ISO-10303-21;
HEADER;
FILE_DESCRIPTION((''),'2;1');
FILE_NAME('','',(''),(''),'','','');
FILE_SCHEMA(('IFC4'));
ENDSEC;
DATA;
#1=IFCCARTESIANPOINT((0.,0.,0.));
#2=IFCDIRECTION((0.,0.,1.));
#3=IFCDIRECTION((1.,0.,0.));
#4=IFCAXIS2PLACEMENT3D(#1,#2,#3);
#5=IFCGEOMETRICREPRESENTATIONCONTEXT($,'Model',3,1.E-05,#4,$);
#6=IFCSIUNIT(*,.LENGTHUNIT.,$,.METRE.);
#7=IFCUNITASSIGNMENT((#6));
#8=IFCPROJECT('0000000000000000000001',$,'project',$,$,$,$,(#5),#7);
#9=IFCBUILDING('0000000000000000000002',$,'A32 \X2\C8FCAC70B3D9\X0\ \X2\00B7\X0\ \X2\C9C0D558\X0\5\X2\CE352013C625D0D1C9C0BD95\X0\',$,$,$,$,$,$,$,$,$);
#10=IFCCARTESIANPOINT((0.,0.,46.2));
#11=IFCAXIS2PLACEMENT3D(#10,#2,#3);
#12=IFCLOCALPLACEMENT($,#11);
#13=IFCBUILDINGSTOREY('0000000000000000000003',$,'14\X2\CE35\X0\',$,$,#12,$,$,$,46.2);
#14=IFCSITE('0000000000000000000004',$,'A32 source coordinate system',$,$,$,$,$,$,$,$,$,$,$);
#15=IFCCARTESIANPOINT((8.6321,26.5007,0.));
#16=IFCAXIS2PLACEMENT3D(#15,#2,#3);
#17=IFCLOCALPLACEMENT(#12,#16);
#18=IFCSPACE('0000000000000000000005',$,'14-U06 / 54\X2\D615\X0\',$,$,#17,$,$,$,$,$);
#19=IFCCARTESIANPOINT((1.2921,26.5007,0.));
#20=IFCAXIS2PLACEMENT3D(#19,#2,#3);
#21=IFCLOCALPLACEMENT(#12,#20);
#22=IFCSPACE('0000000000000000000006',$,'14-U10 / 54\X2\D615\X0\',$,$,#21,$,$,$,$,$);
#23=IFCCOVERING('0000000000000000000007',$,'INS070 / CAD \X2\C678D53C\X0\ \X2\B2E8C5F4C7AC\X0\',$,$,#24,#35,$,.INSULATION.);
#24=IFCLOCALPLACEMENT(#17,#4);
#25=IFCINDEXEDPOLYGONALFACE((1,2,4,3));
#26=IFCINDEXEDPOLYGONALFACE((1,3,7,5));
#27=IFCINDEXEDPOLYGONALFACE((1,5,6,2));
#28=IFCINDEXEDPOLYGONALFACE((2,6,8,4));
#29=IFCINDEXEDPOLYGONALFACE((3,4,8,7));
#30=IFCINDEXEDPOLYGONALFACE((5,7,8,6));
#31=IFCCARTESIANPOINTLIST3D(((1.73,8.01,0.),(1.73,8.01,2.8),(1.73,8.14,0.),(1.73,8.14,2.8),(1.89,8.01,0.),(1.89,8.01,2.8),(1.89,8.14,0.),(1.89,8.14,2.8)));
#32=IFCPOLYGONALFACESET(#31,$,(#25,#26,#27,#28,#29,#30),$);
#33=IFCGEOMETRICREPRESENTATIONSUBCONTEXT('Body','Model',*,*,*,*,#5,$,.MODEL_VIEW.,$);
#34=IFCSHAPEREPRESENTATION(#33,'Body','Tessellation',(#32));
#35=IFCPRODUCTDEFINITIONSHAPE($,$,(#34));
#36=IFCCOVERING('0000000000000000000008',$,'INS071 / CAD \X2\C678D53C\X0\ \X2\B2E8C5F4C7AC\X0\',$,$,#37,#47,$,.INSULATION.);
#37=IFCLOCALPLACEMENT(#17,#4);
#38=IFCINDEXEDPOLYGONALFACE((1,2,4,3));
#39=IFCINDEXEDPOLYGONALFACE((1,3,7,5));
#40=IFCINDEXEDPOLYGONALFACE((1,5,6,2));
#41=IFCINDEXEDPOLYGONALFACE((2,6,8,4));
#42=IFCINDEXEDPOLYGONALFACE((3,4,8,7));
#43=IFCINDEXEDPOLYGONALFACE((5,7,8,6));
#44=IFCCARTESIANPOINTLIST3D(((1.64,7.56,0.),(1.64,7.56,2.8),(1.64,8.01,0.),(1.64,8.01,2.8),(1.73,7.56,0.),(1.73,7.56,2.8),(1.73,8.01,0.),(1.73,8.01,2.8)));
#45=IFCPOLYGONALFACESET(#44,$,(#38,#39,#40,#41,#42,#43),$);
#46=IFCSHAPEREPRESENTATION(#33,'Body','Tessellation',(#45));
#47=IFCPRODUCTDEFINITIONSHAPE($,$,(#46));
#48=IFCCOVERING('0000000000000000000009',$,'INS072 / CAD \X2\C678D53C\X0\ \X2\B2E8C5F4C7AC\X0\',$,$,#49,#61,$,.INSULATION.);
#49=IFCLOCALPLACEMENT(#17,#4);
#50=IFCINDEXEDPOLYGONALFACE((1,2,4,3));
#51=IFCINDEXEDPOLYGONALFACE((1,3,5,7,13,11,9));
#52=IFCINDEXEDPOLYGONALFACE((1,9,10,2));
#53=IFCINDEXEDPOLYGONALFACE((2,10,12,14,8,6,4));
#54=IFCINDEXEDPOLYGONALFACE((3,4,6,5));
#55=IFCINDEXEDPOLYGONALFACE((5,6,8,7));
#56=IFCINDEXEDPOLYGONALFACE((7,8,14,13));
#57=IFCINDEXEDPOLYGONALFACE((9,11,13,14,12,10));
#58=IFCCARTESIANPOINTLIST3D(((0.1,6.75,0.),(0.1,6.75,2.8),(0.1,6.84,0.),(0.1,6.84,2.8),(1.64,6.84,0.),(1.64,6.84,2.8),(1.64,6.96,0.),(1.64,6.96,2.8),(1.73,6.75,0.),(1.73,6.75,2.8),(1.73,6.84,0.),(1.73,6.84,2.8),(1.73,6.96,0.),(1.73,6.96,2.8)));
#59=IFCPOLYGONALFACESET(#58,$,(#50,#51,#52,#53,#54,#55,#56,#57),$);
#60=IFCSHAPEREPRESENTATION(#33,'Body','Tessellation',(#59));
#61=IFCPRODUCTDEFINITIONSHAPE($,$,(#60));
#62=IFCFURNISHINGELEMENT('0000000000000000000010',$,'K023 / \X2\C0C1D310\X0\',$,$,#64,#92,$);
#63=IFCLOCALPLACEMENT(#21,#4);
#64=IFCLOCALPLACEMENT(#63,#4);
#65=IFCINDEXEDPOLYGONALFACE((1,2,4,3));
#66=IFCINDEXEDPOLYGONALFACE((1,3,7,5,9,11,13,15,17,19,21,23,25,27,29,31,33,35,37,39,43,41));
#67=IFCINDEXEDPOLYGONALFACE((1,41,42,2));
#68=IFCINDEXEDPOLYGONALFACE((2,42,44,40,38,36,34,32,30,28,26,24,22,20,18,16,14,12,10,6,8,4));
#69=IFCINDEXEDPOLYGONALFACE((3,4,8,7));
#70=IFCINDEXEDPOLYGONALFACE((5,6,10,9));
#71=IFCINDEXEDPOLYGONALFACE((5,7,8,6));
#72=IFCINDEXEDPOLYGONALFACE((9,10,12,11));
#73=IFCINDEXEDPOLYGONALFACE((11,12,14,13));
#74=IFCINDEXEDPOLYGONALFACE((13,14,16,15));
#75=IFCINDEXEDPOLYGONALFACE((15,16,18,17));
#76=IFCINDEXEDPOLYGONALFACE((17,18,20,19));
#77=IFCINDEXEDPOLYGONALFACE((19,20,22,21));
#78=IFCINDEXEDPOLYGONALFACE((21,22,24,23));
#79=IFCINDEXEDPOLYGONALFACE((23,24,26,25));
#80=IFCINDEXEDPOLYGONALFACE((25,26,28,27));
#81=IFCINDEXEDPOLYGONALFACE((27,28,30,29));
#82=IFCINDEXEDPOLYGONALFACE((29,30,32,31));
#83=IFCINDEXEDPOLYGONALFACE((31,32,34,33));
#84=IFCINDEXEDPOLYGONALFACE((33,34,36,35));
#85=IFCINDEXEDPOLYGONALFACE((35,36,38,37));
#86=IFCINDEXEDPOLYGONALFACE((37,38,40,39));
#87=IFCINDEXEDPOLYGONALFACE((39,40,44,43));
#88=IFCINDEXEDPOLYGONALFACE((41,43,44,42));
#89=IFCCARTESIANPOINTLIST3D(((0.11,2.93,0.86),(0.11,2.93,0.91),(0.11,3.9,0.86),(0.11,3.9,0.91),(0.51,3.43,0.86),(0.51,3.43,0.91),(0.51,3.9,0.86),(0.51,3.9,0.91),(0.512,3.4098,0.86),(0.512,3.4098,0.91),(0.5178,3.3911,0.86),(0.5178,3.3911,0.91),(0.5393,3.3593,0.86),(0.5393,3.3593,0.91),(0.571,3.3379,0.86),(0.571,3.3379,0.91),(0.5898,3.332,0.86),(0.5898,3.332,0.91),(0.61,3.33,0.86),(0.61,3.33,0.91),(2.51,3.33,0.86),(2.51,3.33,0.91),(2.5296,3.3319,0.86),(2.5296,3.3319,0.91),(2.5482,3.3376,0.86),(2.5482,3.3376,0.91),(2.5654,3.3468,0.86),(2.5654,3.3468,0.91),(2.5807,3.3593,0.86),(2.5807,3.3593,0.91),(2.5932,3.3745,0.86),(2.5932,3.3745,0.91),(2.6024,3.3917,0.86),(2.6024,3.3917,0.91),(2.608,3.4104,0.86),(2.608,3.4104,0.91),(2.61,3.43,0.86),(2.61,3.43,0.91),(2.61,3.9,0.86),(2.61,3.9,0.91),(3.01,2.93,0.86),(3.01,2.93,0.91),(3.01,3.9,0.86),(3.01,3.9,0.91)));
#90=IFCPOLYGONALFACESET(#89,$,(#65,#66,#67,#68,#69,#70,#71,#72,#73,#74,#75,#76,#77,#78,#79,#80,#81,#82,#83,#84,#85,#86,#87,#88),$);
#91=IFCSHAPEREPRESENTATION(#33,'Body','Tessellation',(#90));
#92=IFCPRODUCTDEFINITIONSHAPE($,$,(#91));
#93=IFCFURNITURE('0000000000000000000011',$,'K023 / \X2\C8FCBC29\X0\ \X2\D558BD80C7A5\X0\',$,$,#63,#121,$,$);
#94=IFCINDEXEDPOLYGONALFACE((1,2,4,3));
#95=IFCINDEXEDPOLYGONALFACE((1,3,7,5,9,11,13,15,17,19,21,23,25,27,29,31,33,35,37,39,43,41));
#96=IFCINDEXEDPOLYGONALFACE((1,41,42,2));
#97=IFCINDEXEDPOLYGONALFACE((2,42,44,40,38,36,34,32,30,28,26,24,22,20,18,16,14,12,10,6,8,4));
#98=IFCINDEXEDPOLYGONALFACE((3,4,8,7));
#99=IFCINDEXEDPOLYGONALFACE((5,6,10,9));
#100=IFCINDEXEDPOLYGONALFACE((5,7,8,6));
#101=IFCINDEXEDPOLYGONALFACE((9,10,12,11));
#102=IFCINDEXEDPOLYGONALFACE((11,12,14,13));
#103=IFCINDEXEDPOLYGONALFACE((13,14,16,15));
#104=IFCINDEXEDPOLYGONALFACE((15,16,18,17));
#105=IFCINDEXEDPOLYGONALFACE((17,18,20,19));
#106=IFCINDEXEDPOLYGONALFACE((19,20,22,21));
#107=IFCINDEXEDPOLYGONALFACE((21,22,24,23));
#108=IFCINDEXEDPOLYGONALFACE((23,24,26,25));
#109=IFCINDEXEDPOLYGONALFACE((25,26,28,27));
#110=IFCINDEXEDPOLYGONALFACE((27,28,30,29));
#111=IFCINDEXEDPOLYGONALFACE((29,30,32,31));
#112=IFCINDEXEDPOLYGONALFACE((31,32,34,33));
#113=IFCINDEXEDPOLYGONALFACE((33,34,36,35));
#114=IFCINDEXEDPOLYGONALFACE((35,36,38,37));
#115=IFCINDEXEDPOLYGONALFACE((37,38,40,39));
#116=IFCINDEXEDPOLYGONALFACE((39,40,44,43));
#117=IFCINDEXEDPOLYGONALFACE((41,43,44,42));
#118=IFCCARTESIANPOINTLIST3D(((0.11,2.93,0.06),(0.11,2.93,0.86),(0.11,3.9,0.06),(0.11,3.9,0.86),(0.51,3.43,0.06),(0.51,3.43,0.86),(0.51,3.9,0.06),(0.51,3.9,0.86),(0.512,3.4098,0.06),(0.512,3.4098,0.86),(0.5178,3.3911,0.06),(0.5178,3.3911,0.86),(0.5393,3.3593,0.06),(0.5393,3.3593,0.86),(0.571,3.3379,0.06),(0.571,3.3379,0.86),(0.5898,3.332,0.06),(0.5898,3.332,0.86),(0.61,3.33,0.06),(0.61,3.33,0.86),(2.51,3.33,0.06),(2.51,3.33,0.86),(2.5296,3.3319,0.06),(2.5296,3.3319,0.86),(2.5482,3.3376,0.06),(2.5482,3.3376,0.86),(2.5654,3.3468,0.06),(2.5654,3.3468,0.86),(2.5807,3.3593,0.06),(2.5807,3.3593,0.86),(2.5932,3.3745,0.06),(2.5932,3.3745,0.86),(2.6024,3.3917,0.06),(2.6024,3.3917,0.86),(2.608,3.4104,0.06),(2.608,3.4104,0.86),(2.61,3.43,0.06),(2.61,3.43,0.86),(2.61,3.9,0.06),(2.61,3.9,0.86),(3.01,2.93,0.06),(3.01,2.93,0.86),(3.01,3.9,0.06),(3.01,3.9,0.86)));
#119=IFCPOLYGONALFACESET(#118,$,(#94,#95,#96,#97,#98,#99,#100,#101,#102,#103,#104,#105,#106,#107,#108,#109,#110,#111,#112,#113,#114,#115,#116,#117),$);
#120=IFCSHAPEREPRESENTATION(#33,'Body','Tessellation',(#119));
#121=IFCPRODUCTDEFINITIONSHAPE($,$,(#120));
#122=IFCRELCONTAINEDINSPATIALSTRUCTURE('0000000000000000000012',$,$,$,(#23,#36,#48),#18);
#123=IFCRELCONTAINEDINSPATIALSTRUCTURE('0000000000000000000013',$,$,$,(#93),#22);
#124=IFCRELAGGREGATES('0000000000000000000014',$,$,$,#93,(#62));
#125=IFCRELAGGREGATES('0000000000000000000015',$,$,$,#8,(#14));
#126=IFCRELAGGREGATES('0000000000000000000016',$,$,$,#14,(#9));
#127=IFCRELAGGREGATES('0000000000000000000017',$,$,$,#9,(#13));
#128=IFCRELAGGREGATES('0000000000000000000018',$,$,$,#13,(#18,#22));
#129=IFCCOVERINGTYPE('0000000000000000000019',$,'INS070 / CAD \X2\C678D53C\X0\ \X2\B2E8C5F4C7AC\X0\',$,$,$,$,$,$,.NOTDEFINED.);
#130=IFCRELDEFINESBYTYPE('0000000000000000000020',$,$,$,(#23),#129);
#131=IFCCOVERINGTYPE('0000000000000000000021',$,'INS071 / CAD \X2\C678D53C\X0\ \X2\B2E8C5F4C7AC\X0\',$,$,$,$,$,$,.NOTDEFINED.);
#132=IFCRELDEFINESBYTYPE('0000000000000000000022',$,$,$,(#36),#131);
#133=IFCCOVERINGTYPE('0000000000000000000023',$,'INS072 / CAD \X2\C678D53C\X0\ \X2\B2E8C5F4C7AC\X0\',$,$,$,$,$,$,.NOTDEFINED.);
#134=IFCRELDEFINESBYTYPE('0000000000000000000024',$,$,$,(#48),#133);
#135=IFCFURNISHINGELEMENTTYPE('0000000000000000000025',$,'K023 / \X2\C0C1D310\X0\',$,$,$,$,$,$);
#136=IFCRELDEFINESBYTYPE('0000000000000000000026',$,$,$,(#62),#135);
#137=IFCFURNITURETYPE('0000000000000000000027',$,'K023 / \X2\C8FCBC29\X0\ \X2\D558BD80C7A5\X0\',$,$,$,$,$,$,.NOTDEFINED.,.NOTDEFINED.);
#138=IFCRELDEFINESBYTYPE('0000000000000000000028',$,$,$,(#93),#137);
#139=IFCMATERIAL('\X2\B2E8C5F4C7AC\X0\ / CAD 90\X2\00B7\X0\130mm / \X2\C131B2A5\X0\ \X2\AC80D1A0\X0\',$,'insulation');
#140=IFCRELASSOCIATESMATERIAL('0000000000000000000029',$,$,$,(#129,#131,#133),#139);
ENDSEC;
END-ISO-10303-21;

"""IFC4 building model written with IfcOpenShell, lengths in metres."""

from ifc_helpers import new_model, si_unit, frame, origin, origin_with_axes, place, context, subcontext, project, spatial, polyline, outline, extrude, source, transform, mapped, material, type_object, type_shapes, element, aggregate, save


model = new_model("IFC4")

# Units and contexts
model_context = context("Model", 3, precision=1e-05, world=origin_with_axes())
body_context = subcontext(model_context, "Body", "Model", "MODEL_VIEW")
ifc_project = project(units=[si_unit("LENGTHUNIT", "METRE")], contexts=[model_context])

# Site, building, storey, space
storey_placement = place(None, frame((0.0, 0.0, 46.2), z_axis=(0.0, 0.0, 1.0), x_axis=(1.0, 0.0, 0.0)))
space_1_placement = place(storey_placement, frame((8.6321, 26.5007, 0.0), z_axis=(0.0, 0.0, 1.0), x_axis=(1.0, 0.0, 0.0)))
site = spatial("IfcSite", under=ifc_project, Name="A32 source coordinate system")
building = spatial("IfcBuilding", under=site, Name="A32 주거동 · 지하5층–옥탑지붕")
storey = spatial("IfcBuildingStorey", under=building, at=storey_placement, Name="14층", Elevation=46.2)
space_1 = spatial("IfcSpace", under=storey, at=space_1_placement, Name="14-U06 / 54형")

# Coverings
ifc_material = material(Name="단열재 / CAD 90·130mm / 성능 검토", Category="insulation")
covering_type_1 = type_object("IfcCoveringType", Name="INS070 / CAD 외피 단열재", PredefinedType="NOTDEFINED", material=ifc_material)
shared_shape_1 = source(origin(), body_context, "Body", "SweptSolid", [
    extrude(outline(polyline([(1.73, 8.14), (1.89, 8.14), (1.89, 8.01), (1.73, 8.01), (1.73, 8.14)])), origin(), (0.0, 0.0, 1.0), 2.8),
])
type_shapes(covering_type_1, [shared_shape_1])
covering_1_placement = place(space_1_placement, origin_with_axes())
element("IfcCovering", 1, at=covering_1_placement, inside=space_1, type_object=covering_type_1, Name="INS070 / CAD 외피 단열재", PredefinedType="INSULATION", context=body_context, shape_type="MappedRepresentation", body=[
    mapped(shared_shape_1, transform((0.0, 0.0, 0.0), scale=1.0)),
])
covering_type_2 = type_object("IfcCoveringType", Name="INS071 / CAD 외피 단열재", PredefinedType="NOTDEFINED", material=ifc_material)
shared_shape_2 = source(origin(), body_context, "Body", "SweptSolid", [
    extrude(outline(polyline([(1.73, 7.56), (1.64, 7.56), (1.64, 8.01), (1.73, 8.01), (1.73, 7.56)])), origin(), (0.0, 0.0, 1.0), 2.8),
])
type_shapes(covering_type_2, [shared_shape_2])
covering_2_placement = place(space_1_placement, origin_with_axes())
element("IfcCovering", 2, at=covering_2_placement, inside=space_1, type_object=covering_type_2, Name="INS071 / CAD 외피 단열재", PredefinedType="INSULATION", context=body_context, shape_type="MappedRepresentation", body=[
    mapped(shared_shape_2, transform((0.0, 0.0, 0.0), scale=1.0)),
])
covering_type_3 = type_object("IfcCoveringType", Name="INS072 / CAD 외피 단열재", PredefinedType="NOTDEFINED", material=ifc_material)
shared_shape_3 = source(origin(), body_context, "Body", "SweptSolid", [
    extrude(outline(polyline([(1.64, 6.84), (1.64, 6.96), (1.73, 6.96), (1.73, 6.84), (1.73, 6.75), (0.1, 6.75), (0.1, 6.84), (1.64, 6.84)])), origin(), (0.0, 0.0, 1.0), 2.8),
])
type_shapes(covering_type_3, [shared_shape_3])
covering_3_placement = place(space_1_placement, origin_with_axes())
element("IfcCovering", 3, at=covering_3_placement, inside=space_1, type_object=covering_type_3, Name="INS072 / CAD 외피 단열재", PredefinedType="INSULATION", context=body_context, shape_type="MappedRepresentation", body=[
    mapped(shared_shape_3, transform((0.0, 0.0, 0.0), scale=1.0)),
])

# Shared definitions
space_2_placement = place(storey_placement, frame((1.2921, 26.5007, 0.0), z_axis=(0.0, 0.0, 1.0), x_axis=(1.0, 0.0, 0.0)))

# Furnishing element
furnishing_element_type_1 = type_object("IfcFurnishingElementType", Name="K023 / 상판")
shared_shape_4 = source(origin(), body_context, "Body", "SweptSolid", [
    extrude(outline(polyline([(0.51, 3.43), (0.512, 3.4098), (0.5178, 3.3911), (0.5393, 3.3593), (0.571, 3.3379), (0.5898, 3.332), (0.61, 3.33), (2.51, 3.33), (2.5296, 3.3319), (2.5482, 3.3376), (2.5654, 3.3468), (2.5807, 3.3593), (2.5932, 3.3745), (2.6024, 3.3917), (2.608, 3.4104), (2.61, 3.43), (2.61, 3.9), (3.01, 3.9), (3.01, 2.93), (0.11, 2.93), (0.11, 3.9), (0.51, 3.9), (0.51, 3.43)])), frame((0.0, 0.0, 0.86)), (0.0, 0.0, 1.0), 0.05),
])
type_shapes(furnishing_element_type_1, [shared_shape_4])
furniture_1_placement = place(space_2_placement, origin_with_axes())
furnishing_1_placement = place(furniture_1_placement, origin_with_axes())
furnishing_1 = element("IfcFurnishingElement", 4, at=furnishing_1_placement, type_object=furnishing_element_type_1, Name="K023 / 상판", context=body_context, shape_type="MappedRepresentation", body=[
    mapped(shared_shape_4, transform((0.0, 0.0, 0.0), scale=1.0)),
])

# Shared definitions
space_2 = spatial("IfcSpace", under=storey, at=space_2_placement, Name="14-U10 / 54형")

# Furniture
furniture_type_1 = type_object("IfcFurnitureType", Name="K023 / 주방 하부장", AssemblyPlace="NOTDEFINED", PredefinedType="NOTDEFINED")
shared_shape_5 = source(origin(), body_context, "Body", "SweptSolid", [
    extrude(outline(polyline([(0.51, 3.9), (0.51, 3.43), (0.512, 3.4098), (0.5178, 3.3911), (0.5393, 3.3593), (0.571, 3.3379), (0.5898, 3.332), (0.61, 3.33), (2.51, 3.33), (2.5296, 3.3319), (2.5482, 3.3376), (2.5654, 3.3468), (2.5807, 3.3593), (2.5932, 3.3745), (2.6024, 3.3917), (2.608, 3.4104), (2.61, 3.43), (2.61, 3.9), (3.01, 3.9), (3.01, 2.93), (0.11, 2.93), (0.11, 3.9), (0.51, 3.9)])), frame((0.0, 0.0, 0.06)), (0.0, 0.0, 1.0), 0.8),
])
type_shapes(furniture_type_1, [shared_shape_5])
furniture_1 = element("IfcFurniture", 5, at=furniture_1_placement, inside=space_2, type_object=furniture_type_1, Name="K023 / 주방 하부장", context=body_context, shape_type="MappedRepresentation", body=[
    mapped(shared_shape_5, transform((0.0, 0.0, 0.0), scale=1.0)),
])
aggregate(furniture_1, [furnishing_1])

save(model, "model.ifc")
